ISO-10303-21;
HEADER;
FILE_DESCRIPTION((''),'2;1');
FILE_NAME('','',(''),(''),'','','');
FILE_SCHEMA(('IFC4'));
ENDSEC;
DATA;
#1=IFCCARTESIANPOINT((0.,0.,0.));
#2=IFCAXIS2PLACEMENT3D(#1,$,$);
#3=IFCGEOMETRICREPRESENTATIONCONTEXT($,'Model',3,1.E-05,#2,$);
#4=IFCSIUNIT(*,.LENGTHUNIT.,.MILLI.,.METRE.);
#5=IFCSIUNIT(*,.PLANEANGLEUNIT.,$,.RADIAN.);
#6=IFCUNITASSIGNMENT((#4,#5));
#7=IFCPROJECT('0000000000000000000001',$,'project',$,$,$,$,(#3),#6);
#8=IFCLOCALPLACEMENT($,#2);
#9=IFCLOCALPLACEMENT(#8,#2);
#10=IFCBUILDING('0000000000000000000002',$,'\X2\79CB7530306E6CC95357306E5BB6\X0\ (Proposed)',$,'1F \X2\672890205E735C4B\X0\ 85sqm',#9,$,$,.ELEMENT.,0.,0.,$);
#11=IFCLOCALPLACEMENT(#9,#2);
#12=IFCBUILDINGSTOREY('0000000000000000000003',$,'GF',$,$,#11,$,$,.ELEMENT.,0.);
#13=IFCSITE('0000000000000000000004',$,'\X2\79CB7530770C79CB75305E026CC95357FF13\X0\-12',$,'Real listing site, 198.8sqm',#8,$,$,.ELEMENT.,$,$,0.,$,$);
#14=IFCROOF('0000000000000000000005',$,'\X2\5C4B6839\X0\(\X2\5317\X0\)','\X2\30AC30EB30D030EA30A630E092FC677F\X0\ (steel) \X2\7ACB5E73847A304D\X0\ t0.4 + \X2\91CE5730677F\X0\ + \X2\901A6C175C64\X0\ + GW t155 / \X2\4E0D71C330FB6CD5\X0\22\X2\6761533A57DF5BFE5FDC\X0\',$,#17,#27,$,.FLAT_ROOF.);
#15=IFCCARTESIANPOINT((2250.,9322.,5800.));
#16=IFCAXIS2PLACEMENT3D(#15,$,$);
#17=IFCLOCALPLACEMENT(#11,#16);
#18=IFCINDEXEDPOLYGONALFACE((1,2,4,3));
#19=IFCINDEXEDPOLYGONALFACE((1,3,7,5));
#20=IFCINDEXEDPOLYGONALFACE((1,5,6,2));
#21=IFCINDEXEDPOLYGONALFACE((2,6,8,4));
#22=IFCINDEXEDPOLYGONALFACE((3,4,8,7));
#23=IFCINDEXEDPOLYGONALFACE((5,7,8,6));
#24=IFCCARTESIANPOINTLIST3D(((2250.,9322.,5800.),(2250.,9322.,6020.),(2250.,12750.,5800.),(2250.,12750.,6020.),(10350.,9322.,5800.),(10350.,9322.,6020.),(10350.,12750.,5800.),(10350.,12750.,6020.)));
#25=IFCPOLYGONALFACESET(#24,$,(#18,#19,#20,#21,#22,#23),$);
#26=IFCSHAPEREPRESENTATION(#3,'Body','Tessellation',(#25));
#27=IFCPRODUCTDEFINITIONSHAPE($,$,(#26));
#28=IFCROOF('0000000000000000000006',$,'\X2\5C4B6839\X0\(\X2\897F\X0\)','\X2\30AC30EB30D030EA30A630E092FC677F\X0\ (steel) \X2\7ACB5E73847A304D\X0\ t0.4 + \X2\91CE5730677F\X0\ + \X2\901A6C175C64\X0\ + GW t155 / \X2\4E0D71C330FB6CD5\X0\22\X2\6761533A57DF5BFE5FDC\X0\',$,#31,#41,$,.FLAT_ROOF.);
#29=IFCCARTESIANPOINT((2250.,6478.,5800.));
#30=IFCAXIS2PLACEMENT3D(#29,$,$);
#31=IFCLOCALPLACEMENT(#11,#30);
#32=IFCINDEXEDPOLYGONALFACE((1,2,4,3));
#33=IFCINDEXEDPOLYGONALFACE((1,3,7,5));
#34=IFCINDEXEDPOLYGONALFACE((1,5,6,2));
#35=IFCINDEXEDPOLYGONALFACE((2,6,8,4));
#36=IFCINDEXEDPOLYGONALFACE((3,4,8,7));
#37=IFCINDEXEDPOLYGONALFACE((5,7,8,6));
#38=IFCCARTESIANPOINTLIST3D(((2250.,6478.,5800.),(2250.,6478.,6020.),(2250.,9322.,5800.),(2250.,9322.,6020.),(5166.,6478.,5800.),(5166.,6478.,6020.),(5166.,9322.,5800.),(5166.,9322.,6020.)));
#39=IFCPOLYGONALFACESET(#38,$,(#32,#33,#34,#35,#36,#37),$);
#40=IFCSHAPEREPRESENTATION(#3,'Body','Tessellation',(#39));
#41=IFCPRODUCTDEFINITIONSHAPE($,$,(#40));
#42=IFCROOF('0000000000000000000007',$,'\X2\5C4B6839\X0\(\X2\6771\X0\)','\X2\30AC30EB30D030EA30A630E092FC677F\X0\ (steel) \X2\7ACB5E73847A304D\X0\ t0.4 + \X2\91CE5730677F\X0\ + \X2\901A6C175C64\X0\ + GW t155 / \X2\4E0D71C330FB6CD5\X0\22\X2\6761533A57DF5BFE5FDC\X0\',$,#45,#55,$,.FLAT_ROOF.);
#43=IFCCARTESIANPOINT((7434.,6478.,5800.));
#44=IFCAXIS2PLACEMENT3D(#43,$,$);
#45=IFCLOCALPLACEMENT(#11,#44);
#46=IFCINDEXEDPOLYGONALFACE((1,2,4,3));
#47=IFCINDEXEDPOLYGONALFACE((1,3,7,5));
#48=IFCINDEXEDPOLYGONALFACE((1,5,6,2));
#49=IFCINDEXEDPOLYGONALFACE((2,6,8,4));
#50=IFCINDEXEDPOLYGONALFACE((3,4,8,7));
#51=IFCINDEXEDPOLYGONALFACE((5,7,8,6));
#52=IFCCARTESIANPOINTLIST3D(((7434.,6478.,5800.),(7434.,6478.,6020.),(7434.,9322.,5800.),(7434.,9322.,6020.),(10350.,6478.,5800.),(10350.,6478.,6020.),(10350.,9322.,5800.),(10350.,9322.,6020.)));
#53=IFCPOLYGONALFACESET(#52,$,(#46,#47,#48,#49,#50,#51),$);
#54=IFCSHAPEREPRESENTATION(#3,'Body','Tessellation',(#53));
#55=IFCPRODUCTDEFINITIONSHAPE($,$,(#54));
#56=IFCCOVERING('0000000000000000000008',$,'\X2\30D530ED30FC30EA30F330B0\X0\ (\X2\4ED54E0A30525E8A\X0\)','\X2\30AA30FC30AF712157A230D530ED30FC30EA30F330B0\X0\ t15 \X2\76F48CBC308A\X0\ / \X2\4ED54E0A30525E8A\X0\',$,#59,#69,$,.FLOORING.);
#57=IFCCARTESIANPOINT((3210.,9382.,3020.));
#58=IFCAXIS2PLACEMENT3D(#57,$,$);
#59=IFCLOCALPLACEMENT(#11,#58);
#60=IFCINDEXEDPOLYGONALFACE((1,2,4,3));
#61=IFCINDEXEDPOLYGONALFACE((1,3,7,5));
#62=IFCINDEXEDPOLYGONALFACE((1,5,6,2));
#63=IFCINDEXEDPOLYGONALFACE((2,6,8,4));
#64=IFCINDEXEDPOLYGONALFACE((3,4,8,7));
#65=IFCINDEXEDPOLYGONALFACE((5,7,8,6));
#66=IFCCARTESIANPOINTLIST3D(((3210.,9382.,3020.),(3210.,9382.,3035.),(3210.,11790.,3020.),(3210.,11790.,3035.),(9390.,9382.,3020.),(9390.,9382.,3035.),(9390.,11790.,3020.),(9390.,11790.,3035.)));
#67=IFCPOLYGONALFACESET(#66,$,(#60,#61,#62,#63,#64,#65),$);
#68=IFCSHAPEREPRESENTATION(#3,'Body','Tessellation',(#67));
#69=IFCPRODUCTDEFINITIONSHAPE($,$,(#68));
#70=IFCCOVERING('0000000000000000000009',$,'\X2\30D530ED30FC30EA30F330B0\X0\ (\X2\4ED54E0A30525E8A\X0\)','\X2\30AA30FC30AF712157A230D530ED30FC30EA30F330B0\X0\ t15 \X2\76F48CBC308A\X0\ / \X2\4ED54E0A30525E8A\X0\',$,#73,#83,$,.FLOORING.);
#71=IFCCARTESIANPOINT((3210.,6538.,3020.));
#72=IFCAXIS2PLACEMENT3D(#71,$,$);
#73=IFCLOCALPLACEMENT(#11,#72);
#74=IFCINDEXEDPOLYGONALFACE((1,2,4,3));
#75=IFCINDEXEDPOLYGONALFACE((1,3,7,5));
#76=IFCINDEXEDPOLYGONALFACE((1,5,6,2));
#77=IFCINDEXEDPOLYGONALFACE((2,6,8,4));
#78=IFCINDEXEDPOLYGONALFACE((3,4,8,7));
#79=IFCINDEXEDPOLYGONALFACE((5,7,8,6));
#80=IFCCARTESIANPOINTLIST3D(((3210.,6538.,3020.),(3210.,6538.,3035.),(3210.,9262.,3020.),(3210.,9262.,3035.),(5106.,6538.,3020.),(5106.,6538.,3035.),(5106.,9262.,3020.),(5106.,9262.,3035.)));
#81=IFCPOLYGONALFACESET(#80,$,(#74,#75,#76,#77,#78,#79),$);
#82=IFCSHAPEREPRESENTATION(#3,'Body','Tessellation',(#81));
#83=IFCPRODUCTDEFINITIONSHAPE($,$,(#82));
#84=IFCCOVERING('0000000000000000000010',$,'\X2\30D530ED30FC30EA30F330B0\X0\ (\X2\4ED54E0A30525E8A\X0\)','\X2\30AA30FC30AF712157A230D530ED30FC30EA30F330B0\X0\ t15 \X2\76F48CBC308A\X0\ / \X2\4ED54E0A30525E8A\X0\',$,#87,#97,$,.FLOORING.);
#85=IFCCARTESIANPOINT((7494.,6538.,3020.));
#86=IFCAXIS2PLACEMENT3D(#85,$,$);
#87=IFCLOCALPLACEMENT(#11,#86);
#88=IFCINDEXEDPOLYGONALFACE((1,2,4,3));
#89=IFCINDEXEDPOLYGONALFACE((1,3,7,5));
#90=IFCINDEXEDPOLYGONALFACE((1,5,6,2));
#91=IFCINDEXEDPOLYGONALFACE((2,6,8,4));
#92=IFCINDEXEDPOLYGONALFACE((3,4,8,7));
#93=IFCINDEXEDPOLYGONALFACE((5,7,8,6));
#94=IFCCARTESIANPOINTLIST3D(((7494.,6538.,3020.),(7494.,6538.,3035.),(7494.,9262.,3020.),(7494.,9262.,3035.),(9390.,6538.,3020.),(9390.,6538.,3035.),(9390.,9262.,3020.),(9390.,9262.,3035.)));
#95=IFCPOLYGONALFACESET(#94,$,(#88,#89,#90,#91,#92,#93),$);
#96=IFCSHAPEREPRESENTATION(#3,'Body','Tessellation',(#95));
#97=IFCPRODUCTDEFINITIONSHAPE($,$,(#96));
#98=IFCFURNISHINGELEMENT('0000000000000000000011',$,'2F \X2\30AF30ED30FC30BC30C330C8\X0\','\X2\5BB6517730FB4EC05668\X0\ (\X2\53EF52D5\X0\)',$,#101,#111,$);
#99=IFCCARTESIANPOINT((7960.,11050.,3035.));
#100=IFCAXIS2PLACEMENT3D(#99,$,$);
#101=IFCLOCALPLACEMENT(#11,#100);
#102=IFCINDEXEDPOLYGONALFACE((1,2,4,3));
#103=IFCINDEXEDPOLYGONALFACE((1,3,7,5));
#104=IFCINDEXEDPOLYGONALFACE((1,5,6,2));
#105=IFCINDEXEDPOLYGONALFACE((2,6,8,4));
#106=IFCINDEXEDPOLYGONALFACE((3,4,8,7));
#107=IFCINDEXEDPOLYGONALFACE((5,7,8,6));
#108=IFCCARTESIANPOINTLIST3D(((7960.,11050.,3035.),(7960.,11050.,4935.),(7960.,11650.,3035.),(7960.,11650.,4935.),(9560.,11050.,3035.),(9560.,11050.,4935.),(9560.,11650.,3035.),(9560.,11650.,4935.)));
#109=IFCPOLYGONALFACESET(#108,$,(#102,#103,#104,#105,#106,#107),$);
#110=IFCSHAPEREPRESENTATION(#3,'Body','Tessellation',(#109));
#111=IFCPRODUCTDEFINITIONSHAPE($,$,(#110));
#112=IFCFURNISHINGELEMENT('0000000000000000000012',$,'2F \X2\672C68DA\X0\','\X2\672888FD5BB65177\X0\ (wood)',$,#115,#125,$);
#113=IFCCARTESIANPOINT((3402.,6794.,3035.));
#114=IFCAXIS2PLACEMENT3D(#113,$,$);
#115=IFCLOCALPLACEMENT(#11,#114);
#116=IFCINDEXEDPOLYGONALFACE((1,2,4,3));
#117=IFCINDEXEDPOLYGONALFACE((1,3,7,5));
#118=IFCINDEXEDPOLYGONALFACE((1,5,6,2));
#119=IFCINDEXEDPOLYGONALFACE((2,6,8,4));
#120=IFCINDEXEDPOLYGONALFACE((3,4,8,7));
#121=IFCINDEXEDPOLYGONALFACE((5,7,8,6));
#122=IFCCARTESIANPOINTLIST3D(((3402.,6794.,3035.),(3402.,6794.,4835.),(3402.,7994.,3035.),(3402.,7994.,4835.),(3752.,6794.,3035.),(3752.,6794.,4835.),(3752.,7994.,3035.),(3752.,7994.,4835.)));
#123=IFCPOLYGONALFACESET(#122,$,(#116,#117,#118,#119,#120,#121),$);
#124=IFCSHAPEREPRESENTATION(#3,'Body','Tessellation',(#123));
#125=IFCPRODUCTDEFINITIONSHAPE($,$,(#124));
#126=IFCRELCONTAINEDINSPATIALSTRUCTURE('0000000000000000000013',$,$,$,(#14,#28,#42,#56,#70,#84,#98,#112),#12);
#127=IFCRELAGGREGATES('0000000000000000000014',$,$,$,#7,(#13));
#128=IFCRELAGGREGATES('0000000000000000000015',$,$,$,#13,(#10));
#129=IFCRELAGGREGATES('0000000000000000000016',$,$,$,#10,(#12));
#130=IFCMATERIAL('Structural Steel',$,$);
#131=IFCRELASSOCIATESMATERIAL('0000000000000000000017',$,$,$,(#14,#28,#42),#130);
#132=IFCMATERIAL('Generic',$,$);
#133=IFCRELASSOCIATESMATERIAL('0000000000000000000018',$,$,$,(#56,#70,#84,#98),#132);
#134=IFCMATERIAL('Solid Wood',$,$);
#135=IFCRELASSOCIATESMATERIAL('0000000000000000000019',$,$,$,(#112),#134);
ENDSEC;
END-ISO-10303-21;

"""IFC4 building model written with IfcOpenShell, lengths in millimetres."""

from ifc_helpers import new_model, si_unit, frame, frame_2d, origin, place, context, project, spatial, rectangle, extrude, material, element, save


model = new_model("IFC4")

# Units and contexts
model_context = context("Model", 3, precision=1e-05, world=origin())
ifc_project = project(units=[si_unit("LENGTHUNIT", "METRE", prefix="MILLI"), si_unit("PLANEANGLEUNIT", "RADIAN")], contexts=[model_context])

# Site, building, storey
site_placement = place(None, origin())
site = spatial("IfcSite", under=ifc_project, at=site_placement, Name="秋田県秋田市泉南３-12", ObjectType="Real listing site, 198.8sqm", CompositionType="ELEMENT", RefElevation=0.0)
building_placement = place(site_placement, origin())
building = spatial("IfcBuilding", under=site, at=building_placement, Name="秋田の泉南の家 (Proposed)", ObjectType="1F 木造平屋 85sqm", CompositionType="ELEMENT", ElevationOfRefHeight=0.0, ElevationOfTerrain=0.0)
storey_placement = place(building_placement, origin())
storey = spatial("IfcBuildingStorey", under=building, at=storey_placement, Name="GF", CompositionType="ELEMENT", Elevation=0.0)

# Shared definitions
ifc_material_1 = material(Name="Solid Wood")

# Shared definitions
ifc_material_2 = material(Name="Generic")

# Roofs
ifc_material_3 = material(Name="Structural Steel")
for number, where, name in (
    (1, (2250.0, 9322.0, 5800.0), "屋根(北)"),
):
    element("IfcRoof", number, at=place(storey_placement, frame(where)), inside=storey, material=ifc_material_3, Name=name, Description="ガルバリウム鋼板 (steel) 立平葺き t0.4 + 野地板 + 通気層 + GW t155 / 不燃・法22条区域対応", PredefinedType="FLAT_ROOF", context=model_context, shape_type="SweptSolid", body=[
        extrude(rectangle(XDim=8100.0, YDim=3428.0, at=frame_2d((4050.0, 1714.0))), frame((2250.0, 9322.0, 5800.0)), (0.0, 0.0, 1.0), 220.0),
    ])
roof_1_placement = place(storey_placement, frame((2250.0, 6478.0, 5800.0)))
element("IfcRoof", 2, at=roof_1_placement, inside=storey, material=ifc_material_3, Name="屋根(西)", Description="ガルバリウム鋼板 (steel) 立平葺き t0.4 + 野地板 + 通気層 + GW t155 / 不燃・法22条区域対応", PredefinedType="FLAT_ROOF", context=model_context, shape_type="SweptSolid", body=[
    extrude(rectangle(XDim=2916.0, YDim=2844.0, at=frame_2d((1458.0, 1422.0))), frame((2250.0, 6478.0, 5800.0)), (0.0, 0.0, 1.0), 220.0),
])
roof_2_placement = place(storey_placement, frame((7434.0, 6478.0, 5800.0)))
element("IfcRoof", 3, at=roof_2_placement, inside=storey, material=ifc_material_3, Name="屋根(東)", Description="ガルバリウム鋼板 (steel) 立平葺き t0.4 + 野地板 + 通気層 + GW t155 / 不燃・法22条区域対応", PredefinedType="FLAT_ROOF", context=model_context, shape_type="SweptSolid", body=[
    extrude(rectangle(XDim=2916.0, YDim=2844.0, at=frame_2d((1458.0, 1422.0))), frame((7434.0, 6478.0, 5800.0)), (0.0, 0.0, 1.0), 220.0),
])

# Coverings
covering_1_placement = place(storey_placement, frame((3210.0, 9382.0, 3020.0)))
element("IfcCovering", 4, at=covering_1_placement, inside=storey, material=ifc_material_2, Name="フローリング (仕上げ床)", Description="オーク無垢フローリング t15 直貼り / 仕上げ床", PredefinedType="FLOORING", context=model_context, shape_type="SweptSolid", body=[
    extrude(rectangle(XDim=6180.0, YDim=2408.0, at=frame_2d((3090.0, 1204.0))), frame((3210.0, 9382.0, 3020.0)), (0.0, 0.0, 1.0), 15.0),
])
covering_2_placement = place(storey_placement, frame((3210.0, 6538.0, 3020.0)))
element("IfcCovering", 5, at=covering_2_placement, inside=storey, material=ifc_material_2, Name="フローリング (仕上げ床)", Description="オーク無垢フローリング t15 直貼り / 仕上げ床", PredefinedType="FLOORING", context=model_context, shape_type="SweptSolid", body=[
    extrude(rectangle(XDim=1896.0, YDim=2724.0, at=frame_2d((948.0, 1362.0))), frame((3210.0, 6538.0, 3020.0)), (0.0, 0.0, 1.0), 15.0),
])
covering_3_placement = place(storey_placement, frame((7494.0, 6538.0, 3020.0)))
element("IfcCovering", 6, at=covering_3_placement, inside=storey, material=ifc_material_2, Name="フローリング (仕上げ床)", Description="オーク無垢フローリング t15 直貼り / 仕上げ床", PredefinedType="FLOORING", context=model_context, shape_type="SweptSolid", body=[
    extrude(rectangle(XDim=1896.0, YDim=2724.0, at=frame_2d((948.0, 1362.0))), frame((7494.0, 6538.0, 3020.0)), (0.0, 0.0, 1.0), 15.0),
])

# Furnishing elements
furnishing_1_placement = place(storey_placement, frame((7960.0, 11050.0, 3035.0)))
element("IfcFurnishingElement", 7, at=furnishing_1_placement, inside=storey, material=ifc_material_2, Name="2F クローゼット", Description="家具・什器 (可動)", context=model_context, shape_type="SweptSolid", body=[
    extrude(rectangle(XDim=1600.0, YDim=600.0, at=frame_2d((800.0, 300.0))), frame((7960.0, 11050.0, 3035.0)), (0.0, 0.0, 1.0), 1900.0),
])
furnishing_2_placement = place(storey_placement, frame((3402.0, 6794.0, 3035.0)))
element("IfcFurnishingElement", 8, at=furnishing_2_placement, inside=storey, material=ifc_material_1, Name="2F 本棚", Description="木製家具 (wood)", context=model_context, shape_type="SweptSolid", body=[
    extrude(rectangle(XDim=350.0, YDim=1200.0, at=frame_2d((175.0, 600.0))), frame((3402.0, 6794.0, 3035.0)), (0.0, 0.0, 1.0), 1800.0),
])

save(model, "model.ifc")
